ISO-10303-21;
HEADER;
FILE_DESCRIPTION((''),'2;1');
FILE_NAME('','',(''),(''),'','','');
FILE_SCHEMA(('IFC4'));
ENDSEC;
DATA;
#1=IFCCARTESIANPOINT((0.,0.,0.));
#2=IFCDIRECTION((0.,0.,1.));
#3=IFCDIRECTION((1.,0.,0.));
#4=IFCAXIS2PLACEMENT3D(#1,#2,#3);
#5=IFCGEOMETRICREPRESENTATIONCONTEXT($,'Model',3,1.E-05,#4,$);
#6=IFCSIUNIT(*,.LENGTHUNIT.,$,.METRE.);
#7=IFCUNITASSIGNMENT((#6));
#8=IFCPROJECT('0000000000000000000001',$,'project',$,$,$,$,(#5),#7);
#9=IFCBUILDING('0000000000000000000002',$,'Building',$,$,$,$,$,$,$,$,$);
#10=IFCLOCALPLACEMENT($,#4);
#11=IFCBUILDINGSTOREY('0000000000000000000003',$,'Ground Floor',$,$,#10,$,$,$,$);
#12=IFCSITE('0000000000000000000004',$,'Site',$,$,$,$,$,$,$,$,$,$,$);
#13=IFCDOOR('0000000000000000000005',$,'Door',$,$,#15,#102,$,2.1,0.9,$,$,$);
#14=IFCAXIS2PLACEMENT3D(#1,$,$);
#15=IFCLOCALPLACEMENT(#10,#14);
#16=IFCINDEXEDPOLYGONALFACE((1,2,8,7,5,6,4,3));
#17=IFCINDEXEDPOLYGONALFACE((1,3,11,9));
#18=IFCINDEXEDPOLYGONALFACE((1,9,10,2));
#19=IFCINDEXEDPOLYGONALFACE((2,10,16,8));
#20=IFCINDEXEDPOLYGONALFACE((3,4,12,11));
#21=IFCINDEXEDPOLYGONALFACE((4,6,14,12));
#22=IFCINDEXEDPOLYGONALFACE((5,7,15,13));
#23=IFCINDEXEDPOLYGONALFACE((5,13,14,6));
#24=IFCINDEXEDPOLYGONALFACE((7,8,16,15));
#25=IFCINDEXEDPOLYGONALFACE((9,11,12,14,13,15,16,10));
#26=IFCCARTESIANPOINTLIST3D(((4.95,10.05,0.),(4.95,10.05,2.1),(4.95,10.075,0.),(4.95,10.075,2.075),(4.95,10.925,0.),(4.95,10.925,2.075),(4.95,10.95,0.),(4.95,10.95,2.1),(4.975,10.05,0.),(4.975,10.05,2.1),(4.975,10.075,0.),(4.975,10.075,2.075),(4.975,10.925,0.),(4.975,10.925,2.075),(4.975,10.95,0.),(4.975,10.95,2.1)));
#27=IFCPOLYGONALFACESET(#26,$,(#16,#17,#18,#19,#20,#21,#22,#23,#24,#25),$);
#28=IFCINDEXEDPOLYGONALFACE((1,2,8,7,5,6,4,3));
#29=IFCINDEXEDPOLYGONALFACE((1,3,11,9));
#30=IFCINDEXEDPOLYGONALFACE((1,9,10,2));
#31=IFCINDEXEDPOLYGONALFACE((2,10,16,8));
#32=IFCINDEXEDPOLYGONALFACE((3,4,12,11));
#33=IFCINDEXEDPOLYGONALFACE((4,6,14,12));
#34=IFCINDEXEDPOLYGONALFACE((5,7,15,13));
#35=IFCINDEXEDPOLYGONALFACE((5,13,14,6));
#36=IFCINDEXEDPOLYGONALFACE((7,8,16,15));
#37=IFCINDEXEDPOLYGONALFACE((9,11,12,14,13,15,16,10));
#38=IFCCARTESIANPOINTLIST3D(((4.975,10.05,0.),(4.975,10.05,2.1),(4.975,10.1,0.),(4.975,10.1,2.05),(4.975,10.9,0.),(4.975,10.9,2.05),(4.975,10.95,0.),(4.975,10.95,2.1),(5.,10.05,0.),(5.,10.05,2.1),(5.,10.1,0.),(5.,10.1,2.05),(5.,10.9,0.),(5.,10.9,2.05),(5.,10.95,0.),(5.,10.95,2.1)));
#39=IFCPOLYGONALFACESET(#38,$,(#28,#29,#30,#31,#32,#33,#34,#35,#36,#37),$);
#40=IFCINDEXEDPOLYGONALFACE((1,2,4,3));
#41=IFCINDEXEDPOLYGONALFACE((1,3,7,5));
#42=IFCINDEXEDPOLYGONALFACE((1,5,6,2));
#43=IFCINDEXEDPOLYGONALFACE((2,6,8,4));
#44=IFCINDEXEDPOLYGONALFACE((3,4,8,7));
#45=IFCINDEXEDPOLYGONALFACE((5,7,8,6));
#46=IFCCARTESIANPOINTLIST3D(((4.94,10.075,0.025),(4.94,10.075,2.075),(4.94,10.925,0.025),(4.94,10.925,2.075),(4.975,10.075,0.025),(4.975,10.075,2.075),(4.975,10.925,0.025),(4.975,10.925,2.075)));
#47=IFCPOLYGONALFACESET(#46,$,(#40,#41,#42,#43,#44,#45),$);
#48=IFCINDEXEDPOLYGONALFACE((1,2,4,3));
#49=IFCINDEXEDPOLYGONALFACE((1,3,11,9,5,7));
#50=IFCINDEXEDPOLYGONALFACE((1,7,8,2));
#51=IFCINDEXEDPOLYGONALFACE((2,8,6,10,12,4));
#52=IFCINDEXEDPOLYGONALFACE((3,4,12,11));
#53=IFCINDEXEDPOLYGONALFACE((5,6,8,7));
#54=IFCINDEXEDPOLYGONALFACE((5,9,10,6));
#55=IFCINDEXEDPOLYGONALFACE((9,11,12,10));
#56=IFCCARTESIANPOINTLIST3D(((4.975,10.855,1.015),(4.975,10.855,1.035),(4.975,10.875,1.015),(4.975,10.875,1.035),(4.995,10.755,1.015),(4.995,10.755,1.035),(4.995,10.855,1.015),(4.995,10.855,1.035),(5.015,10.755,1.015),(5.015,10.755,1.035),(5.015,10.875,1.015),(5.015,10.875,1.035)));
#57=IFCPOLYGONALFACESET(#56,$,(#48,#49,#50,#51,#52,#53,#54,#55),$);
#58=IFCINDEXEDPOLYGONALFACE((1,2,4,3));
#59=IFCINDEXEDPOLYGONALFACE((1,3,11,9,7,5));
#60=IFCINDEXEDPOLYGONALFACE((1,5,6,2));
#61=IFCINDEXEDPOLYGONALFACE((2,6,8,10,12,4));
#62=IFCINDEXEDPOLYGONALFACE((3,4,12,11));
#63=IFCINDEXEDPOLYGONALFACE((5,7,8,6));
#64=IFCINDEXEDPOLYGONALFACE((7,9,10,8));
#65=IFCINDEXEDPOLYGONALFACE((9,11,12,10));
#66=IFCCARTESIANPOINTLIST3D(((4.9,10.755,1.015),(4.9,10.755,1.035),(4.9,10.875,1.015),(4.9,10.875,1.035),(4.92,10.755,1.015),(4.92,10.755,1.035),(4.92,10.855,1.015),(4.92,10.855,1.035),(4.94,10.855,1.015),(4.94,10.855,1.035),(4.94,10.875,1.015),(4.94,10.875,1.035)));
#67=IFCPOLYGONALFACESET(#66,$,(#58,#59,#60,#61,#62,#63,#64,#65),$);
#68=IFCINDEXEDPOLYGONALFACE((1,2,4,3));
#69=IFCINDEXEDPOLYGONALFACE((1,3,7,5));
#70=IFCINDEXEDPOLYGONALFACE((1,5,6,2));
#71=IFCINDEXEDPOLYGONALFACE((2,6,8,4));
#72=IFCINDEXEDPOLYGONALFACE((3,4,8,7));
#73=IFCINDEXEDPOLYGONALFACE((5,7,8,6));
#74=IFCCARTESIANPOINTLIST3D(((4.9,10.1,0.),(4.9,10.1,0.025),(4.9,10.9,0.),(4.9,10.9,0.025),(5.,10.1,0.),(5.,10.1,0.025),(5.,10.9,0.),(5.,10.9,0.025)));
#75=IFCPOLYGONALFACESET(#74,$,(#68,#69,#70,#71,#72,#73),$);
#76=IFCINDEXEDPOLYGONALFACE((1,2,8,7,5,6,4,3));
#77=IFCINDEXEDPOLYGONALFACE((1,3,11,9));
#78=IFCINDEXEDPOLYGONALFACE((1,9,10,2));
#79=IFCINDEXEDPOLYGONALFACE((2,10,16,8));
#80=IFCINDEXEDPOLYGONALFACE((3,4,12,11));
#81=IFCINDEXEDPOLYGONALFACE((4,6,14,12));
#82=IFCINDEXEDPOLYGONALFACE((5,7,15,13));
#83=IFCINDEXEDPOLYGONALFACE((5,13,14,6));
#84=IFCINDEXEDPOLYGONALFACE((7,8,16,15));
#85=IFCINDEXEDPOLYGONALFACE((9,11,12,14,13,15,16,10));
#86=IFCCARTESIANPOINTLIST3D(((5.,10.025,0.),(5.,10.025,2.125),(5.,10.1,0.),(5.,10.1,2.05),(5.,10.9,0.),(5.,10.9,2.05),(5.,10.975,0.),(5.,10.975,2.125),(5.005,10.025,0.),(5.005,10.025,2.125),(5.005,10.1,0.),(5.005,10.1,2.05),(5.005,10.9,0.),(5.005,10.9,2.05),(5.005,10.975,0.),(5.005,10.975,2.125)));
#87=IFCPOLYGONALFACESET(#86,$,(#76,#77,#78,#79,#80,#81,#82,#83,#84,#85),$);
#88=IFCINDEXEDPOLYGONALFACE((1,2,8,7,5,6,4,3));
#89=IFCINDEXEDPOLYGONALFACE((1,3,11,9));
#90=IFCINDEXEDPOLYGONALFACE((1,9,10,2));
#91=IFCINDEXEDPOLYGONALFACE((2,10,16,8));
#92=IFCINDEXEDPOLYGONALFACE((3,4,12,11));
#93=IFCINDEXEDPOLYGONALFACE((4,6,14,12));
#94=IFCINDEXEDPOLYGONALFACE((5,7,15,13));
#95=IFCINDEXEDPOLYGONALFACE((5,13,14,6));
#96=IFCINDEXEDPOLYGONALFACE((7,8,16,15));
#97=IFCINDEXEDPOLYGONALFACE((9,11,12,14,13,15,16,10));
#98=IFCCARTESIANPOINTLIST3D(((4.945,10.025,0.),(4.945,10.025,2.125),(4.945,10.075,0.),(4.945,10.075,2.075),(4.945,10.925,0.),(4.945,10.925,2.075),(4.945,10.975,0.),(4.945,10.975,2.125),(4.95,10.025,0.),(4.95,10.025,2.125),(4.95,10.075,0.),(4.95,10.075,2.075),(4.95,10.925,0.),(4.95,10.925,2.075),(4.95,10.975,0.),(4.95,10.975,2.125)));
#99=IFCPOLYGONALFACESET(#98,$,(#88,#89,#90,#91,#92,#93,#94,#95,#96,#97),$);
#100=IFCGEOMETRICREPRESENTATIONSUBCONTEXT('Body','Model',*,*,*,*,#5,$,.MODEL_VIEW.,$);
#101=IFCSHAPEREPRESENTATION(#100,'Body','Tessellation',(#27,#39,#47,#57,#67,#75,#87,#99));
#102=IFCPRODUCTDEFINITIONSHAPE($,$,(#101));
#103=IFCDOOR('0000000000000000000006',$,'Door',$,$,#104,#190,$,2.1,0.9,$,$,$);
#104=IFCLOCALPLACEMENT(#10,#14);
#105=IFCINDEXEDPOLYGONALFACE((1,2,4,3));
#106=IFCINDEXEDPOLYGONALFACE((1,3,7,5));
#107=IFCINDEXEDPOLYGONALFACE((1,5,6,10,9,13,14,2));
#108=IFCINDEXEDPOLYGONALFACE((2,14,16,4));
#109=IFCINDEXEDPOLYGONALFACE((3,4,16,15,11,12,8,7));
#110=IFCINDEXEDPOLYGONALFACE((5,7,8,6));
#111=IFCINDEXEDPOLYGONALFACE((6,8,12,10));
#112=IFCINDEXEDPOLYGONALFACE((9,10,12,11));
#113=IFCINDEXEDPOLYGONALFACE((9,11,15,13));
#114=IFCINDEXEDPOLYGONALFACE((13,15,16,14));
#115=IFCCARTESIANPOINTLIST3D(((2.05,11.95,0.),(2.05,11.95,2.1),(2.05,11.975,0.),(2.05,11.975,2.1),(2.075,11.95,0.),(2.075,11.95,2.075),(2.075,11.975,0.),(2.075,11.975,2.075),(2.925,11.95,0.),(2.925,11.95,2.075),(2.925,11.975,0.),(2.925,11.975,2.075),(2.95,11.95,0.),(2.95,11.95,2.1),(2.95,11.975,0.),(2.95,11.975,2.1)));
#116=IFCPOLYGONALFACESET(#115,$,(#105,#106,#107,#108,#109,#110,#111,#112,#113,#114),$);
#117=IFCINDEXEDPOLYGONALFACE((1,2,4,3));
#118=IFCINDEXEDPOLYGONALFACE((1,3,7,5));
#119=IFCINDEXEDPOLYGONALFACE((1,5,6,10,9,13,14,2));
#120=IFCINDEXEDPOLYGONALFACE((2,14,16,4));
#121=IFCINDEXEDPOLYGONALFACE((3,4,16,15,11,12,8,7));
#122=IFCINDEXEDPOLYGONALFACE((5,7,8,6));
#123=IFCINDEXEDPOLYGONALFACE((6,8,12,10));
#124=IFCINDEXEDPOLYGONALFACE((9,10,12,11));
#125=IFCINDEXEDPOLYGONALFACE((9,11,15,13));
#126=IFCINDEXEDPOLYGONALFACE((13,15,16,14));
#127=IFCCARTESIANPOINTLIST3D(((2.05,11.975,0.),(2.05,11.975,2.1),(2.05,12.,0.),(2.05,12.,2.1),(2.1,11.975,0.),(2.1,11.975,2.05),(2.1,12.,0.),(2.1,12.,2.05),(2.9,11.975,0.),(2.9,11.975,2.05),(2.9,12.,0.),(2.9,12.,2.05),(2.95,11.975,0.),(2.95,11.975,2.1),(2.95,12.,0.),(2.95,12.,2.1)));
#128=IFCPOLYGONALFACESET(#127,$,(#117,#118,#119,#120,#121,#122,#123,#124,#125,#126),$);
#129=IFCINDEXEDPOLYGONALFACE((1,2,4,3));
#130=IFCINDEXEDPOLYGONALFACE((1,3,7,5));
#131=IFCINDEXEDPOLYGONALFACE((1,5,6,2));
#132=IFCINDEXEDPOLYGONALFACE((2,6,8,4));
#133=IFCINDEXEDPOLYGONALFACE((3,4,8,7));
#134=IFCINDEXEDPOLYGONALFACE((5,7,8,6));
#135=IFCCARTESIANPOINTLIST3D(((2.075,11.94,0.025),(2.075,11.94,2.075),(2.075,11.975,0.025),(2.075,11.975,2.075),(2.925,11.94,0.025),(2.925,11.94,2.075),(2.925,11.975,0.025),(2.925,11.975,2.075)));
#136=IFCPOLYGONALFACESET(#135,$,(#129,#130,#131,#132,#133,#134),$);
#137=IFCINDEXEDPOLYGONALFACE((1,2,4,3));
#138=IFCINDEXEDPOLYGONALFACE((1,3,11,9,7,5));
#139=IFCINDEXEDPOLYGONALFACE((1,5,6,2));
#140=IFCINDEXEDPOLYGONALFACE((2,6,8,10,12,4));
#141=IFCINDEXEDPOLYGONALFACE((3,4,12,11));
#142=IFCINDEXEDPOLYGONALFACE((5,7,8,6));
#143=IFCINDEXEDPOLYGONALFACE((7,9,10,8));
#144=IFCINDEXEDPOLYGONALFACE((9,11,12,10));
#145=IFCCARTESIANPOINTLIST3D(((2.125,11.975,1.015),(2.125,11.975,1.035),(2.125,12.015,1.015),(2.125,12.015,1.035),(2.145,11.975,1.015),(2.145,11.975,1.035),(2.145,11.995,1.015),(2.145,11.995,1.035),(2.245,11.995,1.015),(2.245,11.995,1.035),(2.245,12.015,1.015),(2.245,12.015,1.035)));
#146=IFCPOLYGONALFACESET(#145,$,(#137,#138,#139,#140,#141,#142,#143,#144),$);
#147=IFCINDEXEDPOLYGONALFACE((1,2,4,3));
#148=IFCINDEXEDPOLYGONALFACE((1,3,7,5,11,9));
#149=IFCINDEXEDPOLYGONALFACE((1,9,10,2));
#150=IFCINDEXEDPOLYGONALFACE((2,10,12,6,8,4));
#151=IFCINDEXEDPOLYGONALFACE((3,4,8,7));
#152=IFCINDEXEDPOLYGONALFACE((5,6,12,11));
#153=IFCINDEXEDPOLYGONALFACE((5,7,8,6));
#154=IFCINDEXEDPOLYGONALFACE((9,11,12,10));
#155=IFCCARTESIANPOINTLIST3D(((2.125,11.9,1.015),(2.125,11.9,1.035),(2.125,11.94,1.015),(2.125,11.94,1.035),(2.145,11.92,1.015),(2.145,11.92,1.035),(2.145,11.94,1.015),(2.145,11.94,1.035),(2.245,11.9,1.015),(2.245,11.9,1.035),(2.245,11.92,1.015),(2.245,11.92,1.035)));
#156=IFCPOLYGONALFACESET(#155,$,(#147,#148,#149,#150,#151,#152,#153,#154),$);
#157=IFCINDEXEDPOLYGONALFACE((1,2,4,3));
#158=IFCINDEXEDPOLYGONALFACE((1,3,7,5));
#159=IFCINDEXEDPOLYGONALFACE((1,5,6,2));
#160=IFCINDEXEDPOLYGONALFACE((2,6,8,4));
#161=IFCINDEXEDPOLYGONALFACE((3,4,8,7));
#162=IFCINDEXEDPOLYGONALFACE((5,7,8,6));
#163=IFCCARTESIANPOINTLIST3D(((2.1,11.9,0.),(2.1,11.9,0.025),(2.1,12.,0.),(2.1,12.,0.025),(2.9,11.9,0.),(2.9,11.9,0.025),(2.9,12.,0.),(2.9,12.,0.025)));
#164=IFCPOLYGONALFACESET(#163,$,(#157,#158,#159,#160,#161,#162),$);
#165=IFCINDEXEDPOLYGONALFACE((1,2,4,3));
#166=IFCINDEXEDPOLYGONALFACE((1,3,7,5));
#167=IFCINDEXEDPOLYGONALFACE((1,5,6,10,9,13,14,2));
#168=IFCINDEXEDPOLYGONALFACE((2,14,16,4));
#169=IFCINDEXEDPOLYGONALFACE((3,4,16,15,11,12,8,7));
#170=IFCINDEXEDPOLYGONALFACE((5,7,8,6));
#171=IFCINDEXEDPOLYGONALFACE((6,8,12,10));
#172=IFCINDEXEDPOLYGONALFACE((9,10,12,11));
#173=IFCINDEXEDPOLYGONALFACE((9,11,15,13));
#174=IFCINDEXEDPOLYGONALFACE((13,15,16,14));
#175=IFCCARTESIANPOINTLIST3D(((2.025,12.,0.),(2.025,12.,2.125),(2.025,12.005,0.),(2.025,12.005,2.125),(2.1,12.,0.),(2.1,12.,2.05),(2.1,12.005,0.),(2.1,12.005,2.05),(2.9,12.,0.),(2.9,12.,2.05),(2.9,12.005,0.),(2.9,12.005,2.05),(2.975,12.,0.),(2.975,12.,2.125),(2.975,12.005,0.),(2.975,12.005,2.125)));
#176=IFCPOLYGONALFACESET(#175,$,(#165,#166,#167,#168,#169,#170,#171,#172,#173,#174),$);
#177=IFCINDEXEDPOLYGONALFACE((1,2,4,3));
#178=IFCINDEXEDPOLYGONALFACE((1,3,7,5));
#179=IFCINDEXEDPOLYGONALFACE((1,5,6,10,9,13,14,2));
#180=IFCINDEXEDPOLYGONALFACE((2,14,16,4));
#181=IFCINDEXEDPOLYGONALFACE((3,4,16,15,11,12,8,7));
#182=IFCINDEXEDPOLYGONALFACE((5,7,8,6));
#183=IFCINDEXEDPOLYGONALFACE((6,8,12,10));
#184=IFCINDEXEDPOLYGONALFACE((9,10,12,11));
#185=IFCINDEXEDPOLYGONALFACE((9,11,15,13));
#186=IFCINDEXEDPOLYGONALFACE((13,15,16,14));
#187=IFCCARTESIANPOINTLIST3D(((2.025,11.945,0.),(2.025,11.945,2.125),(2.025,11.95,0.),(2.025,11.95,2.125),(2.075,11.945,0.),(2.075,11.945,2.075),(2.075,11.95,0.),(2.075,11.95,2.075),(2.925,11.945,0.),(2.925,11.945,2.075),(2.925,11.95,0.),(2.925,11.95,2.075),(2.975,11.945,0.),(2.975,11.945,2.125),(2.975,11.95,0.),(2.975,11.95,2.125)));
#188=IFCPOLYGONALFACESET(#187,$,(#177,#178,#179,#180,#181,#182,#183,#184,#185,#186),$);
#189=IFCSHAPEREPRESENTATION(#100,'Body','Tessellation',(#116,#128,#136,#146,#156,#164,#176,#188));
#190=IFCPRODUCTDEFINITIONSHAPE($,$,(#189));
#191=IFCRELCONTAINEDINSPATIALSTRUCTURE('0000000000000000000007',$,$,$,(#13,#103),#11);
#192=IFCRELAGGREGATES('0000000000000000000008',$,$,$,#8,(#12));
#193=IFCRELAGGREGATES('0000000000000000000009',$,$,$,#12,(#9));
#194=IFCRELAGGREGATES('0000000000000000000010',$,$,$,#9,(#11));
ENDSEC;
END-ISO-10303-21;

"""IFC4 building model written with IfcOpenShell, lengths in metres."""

from ifc_helpers import new_model, si_unit, frame, origin_with_axes, place, context, subcontext, project, spatial, line, indexed_curve, outline, extrude, element, save


model = new_model("IFC4")

# Units and contexts
model_context = context("Model", 3, precision=1e-05, world=origin_with_axes())
body_context = subcontext(model_context, "Body", "Model", "MODEL_VIEW")
ifc_project = project(units=[si_unit("LENGTHUNIT", "METRE")], contexts=[model_context])

# Site, building, storey
site = spatial("IfcSite", under=ifc_project, Name="Site")
building = spatial("IfcBuilding", under=site, Name="Building")
storey_placement = place(None, origin_with_axes())
storey = spatial("IfcBuildingStorey", under=building, at=storey_placement, Name="Ground Floor")

# Doors
door_1_placement = place(storey_placement, frame((5.0, 10.05, 0.0), z_axis=(0.0, 0.0, 1.0), x_axis=(0.0, 1.0, 0.0)))
element("IfcDoor", 1, at=door_1_placement, inside=storey, Name="Door", OverallHeight=2.1, OverallWidth=0.9, context=body_context, shape_type="SweptSolid", body=[
    extrude(outline(indexed_curve([(0.0, 0.0), (0.0, 2.1), (0.9, 2.1), (0.9, 0.0), (0.875, 0.0), (0.875, 2.075), (0.025, 2.075), (0.025, 0.0)], segments=[line(1, 2, 3, 4, 5, 6, 7, 8, 1)])), frame((0.0, 0.025, 0.0), z_axis=(0.0, -1.0, 0.0), x_axis=(1.0, 0.0, 0.0)), (0.0, 0.0, -1.0), 0.025),
    extrude(outline(indexed_curve([(0.0, 0.0), (0.0, 2.1), (0.9, 2.1), (0.9, 0.0), (0.85, 0.0), (0.85, 2.05), (0.05, 2.05), (0.05, 0.0)], segments=[line(1, 2, 3, 4, 5, 6, 7, 8, 1)])), frame((0.0, 0.0, 0.0), z_axis=(0.0, -1.0, 0.0), x_axis=(1.0, 0.0, 0.0)), (0.0, 0.0, -1.0), 0.025),
    extrude(outline(indexed_curve([(0.0, 0.0), (0.85, 0.0), (0.85, 0.035), (0.0, 0.035)], segments=[line(1, 2, 3, 4, 1)])), frame((0.025, 0.025, 0.025), z_axis=(0.0, 0.0, 1.0), x_axis=(1.0, 0.0, 0.0)), (0.0, 0.0, 1.0), 2.05),
    extrude(outline(indexed_curve([(0.0, 0.0), (0.0, -0.04), (-0.12, -0.04), (-0.12, -0.02), (-0.02, -0.02), (-0.02, 0.0)], segments=[line(1, 2, 3, 4, 5, 6, 1)])), frame((0.825, 0.025, 1.015), z_axis=(0.0, 0.0, 1.0), x_axis=(1.0, 0.0, 0.0)), (0.0, 0.0, 1.0), 0.02),
    extrude(outline(indexed_curve([(0.0, 0.0), (0.0, 0.04), (-0.12, 0.04), (-0.12, 0.02), (-0.02, 0.02), (-0.02, 0.0)], segments=[line(1, 2, 3, 4, 5, 6, 1)])), frame((0.825, 0.06, 1.015), z_axis=(0.0, 0.0, 1.0), x_axis=(1.0, 0.0, 0.0)), (0.0, 0.0, 1.0), 0.02),
    extrude(outline(indexed_curve([(0.0, 0.0), (0.8, 0.0), (0.8, 0.1), (0.0, 0.1)], segments=[line(1, 2, 3, 4, 1)])), frame((0.05, 0.0, 0.0), z_axis=(0.0, 0.0, 1.0), x_axis=(1.0, 0.0, 0.0)), (0.0, 0.0, 1.0), 0.025),
    extrude(outline(indexed_curve([(0.0, 0.0), (0.0, 2.125), (0.95, 2.125), (0.95, 0.0), (0.875, 0.0), (0.875, 2.05), (0.075, 2.05), (0.075, 0.0)], segments=[line(1, 2, 3, 4, 5, 6, 7, 8, 1)])), frame((-0.025, -0.005, 0.0), z_axis=(0.0, -1.0, 0.0), x_axis=(1.0, 0.0, 0.0)), (0.0, 0.0, -1.0), 0.005),
    extrude(outline(indexed_curve([(0.0, 0.0), (0.0, 2.125), (0.95, 2.125), (0.95, 0.0), (0.9, 0.0), (0.9, 2.075), (0.05, 2.075), (0.05, 0.0)], segments=[line(1, 2, 3, 4, 5, 6, 7, 8, 1)])), frame((-0.025, 0.05, 0.0), z_axis=(0.0, -1.0, 0.0), x_axis=(1.0, 0.0, 0.0)), (0.0, 0.0, -1.0), 0.005),
])
door_2_placement = place(storey_placement, frame((2.95, 12.0, 0.0), z_axis=(0.0, 0.0, 1.0), x_axis=(-1.0, 0.0, 0.0)))
element("IfcDoor", 2, at=door_2_placement, inside=storey, Name="Door", OverallHeight=2.1, OverallWidth=0.9, context=body_context, shape_type="SweptSolid", body=[
    extrude(outline(indexed_curve([(0.0, 0.0), (0.0, 2.1), (0.9, 2.1), (0.9, 0.0), (0.875, 0.0), (0.875, 2.075), (0.025, 2.075), (0.025, 0.0)], segments=[line(1, 2, 3, 4, 5, 6, 7, 8, 1)])), frame((0.0, 0.025, 0.0), z_axis=(0.0, -1.0, 0.0), x_axis=(1.0, 0.0, 0.0)), (0.0, 0.0, -1.0), 0.025),
    extrude(outline(indexed_curve([(0.0, 0.0), (0.0, 2.1), (0.9, 2.1), (0.9, 0.0), (0.85, 0.0), (0.85, 2.05), (0.05, 2.05), (0.05, 0.0)], segments=[line(1, 2, 3, 4, 5, 6, 7, 8, 1)])), frame((0.0, 0.0, 0.0), z_axis=(0.0, -1.0, 0.0), x_axis=(1.0, 0.0, 0.0)), (0.0, 0.0, -1.0), 0.025),
    extrude(outline(indexed_curve([(0.0, 0.0), (0.85, 0.0), (0.85, 0.035), (0.0, 0.035)], segments=[line(1, 2, 3, 4, 1)])), frame((0.025, 0.025, 0.025), z_axis=(0.0, 0.0, 1.0), x_axis=(1.0, 0.0, 0.0)), (0.0, 0.0, 1.0), 2.05),
    extrude(outline(indexed_curve([(0.0, 0.0), (0.0, -0.04), (-0.12, -0.04), (-0.12, -0.02), (-0.02, -0.02), (-0.02, 0.0)], segments=[line(1, 2, 3, 4, 5, 6, 1)])), frame((0.825, 0.025, 1.015), z_axis=(0.0, 0.0, 1.0), x_axis=(1.0, 0.0, 0.0)), (0.0, 0.0, 1.0), 0.02),
    extrude(outline(indexed_curve([(0.0, 0.0), (0.0, 0.04), (-0.12, 0.04), (-0.12, 0.02), (-0.02, 0.02), (-0.02, 0.0)], segments=[line(1, 2, 3, 4, 5, 6, 1)])), frame((0.825, 0.06, 1.015), z_axis=(0.0, 0.0, 1.0), x_axis=(1.0, 0.0, 0.0)), (0.0, 0.0, 1.0), 0.02),
    extrude(outline(indexed_curve([(0.0, 0.0), (0.8, 0.0), (0.8, 0.1), (0.0, 0.1)], segments=[line(1, 2, 3, 4, 1)])), frame((0.05, 0.0, 0.0), z_axis=(0.0, 0.0, 1.0), x_axis=(1.0, 0.0, 0.0)), (0.0, 0.0, 1.0), 0.025),
    extrude(outline(indexed_curve([(0.0, 0.0), (0.0, 2.125), (0.95, 2.125), (0.95, 0.0), (0.875, 0.0), (0.875, 2.05), (0.075, 2.05), (0.075, 0.0)], segments=[line(1, 2, 3, 4, 5, 6, 7, 8, 1)])), frame((-0.025, -0.005, 0.0), z_axis=(0.0, -1.0, 0.0), x_axis=(1.0, 0.0, 0.0)), (0.0, 0.0, -1.0), 0.005),
    extrude(outline(indexed_curve([(0.0, 0.0), (0.0, 2.125), (0.95, 2.125), (0.95, 0.0), (0.9, 0.0), (0.9, 2.075), (0.05, 2.075), (0.05, 0.0)], segments=[line(1, 2, 3, 4, 5, 6, 7, 8, 1)])), frame((-0.025, 0.05, 0.0), z_axis=(0.0, -1.0, 0.0), x_axis=(1.0, 0.0, 0.0)), (0.0, 0.0, -1.0), 0.005),
])

save(model, "model.ifc")
